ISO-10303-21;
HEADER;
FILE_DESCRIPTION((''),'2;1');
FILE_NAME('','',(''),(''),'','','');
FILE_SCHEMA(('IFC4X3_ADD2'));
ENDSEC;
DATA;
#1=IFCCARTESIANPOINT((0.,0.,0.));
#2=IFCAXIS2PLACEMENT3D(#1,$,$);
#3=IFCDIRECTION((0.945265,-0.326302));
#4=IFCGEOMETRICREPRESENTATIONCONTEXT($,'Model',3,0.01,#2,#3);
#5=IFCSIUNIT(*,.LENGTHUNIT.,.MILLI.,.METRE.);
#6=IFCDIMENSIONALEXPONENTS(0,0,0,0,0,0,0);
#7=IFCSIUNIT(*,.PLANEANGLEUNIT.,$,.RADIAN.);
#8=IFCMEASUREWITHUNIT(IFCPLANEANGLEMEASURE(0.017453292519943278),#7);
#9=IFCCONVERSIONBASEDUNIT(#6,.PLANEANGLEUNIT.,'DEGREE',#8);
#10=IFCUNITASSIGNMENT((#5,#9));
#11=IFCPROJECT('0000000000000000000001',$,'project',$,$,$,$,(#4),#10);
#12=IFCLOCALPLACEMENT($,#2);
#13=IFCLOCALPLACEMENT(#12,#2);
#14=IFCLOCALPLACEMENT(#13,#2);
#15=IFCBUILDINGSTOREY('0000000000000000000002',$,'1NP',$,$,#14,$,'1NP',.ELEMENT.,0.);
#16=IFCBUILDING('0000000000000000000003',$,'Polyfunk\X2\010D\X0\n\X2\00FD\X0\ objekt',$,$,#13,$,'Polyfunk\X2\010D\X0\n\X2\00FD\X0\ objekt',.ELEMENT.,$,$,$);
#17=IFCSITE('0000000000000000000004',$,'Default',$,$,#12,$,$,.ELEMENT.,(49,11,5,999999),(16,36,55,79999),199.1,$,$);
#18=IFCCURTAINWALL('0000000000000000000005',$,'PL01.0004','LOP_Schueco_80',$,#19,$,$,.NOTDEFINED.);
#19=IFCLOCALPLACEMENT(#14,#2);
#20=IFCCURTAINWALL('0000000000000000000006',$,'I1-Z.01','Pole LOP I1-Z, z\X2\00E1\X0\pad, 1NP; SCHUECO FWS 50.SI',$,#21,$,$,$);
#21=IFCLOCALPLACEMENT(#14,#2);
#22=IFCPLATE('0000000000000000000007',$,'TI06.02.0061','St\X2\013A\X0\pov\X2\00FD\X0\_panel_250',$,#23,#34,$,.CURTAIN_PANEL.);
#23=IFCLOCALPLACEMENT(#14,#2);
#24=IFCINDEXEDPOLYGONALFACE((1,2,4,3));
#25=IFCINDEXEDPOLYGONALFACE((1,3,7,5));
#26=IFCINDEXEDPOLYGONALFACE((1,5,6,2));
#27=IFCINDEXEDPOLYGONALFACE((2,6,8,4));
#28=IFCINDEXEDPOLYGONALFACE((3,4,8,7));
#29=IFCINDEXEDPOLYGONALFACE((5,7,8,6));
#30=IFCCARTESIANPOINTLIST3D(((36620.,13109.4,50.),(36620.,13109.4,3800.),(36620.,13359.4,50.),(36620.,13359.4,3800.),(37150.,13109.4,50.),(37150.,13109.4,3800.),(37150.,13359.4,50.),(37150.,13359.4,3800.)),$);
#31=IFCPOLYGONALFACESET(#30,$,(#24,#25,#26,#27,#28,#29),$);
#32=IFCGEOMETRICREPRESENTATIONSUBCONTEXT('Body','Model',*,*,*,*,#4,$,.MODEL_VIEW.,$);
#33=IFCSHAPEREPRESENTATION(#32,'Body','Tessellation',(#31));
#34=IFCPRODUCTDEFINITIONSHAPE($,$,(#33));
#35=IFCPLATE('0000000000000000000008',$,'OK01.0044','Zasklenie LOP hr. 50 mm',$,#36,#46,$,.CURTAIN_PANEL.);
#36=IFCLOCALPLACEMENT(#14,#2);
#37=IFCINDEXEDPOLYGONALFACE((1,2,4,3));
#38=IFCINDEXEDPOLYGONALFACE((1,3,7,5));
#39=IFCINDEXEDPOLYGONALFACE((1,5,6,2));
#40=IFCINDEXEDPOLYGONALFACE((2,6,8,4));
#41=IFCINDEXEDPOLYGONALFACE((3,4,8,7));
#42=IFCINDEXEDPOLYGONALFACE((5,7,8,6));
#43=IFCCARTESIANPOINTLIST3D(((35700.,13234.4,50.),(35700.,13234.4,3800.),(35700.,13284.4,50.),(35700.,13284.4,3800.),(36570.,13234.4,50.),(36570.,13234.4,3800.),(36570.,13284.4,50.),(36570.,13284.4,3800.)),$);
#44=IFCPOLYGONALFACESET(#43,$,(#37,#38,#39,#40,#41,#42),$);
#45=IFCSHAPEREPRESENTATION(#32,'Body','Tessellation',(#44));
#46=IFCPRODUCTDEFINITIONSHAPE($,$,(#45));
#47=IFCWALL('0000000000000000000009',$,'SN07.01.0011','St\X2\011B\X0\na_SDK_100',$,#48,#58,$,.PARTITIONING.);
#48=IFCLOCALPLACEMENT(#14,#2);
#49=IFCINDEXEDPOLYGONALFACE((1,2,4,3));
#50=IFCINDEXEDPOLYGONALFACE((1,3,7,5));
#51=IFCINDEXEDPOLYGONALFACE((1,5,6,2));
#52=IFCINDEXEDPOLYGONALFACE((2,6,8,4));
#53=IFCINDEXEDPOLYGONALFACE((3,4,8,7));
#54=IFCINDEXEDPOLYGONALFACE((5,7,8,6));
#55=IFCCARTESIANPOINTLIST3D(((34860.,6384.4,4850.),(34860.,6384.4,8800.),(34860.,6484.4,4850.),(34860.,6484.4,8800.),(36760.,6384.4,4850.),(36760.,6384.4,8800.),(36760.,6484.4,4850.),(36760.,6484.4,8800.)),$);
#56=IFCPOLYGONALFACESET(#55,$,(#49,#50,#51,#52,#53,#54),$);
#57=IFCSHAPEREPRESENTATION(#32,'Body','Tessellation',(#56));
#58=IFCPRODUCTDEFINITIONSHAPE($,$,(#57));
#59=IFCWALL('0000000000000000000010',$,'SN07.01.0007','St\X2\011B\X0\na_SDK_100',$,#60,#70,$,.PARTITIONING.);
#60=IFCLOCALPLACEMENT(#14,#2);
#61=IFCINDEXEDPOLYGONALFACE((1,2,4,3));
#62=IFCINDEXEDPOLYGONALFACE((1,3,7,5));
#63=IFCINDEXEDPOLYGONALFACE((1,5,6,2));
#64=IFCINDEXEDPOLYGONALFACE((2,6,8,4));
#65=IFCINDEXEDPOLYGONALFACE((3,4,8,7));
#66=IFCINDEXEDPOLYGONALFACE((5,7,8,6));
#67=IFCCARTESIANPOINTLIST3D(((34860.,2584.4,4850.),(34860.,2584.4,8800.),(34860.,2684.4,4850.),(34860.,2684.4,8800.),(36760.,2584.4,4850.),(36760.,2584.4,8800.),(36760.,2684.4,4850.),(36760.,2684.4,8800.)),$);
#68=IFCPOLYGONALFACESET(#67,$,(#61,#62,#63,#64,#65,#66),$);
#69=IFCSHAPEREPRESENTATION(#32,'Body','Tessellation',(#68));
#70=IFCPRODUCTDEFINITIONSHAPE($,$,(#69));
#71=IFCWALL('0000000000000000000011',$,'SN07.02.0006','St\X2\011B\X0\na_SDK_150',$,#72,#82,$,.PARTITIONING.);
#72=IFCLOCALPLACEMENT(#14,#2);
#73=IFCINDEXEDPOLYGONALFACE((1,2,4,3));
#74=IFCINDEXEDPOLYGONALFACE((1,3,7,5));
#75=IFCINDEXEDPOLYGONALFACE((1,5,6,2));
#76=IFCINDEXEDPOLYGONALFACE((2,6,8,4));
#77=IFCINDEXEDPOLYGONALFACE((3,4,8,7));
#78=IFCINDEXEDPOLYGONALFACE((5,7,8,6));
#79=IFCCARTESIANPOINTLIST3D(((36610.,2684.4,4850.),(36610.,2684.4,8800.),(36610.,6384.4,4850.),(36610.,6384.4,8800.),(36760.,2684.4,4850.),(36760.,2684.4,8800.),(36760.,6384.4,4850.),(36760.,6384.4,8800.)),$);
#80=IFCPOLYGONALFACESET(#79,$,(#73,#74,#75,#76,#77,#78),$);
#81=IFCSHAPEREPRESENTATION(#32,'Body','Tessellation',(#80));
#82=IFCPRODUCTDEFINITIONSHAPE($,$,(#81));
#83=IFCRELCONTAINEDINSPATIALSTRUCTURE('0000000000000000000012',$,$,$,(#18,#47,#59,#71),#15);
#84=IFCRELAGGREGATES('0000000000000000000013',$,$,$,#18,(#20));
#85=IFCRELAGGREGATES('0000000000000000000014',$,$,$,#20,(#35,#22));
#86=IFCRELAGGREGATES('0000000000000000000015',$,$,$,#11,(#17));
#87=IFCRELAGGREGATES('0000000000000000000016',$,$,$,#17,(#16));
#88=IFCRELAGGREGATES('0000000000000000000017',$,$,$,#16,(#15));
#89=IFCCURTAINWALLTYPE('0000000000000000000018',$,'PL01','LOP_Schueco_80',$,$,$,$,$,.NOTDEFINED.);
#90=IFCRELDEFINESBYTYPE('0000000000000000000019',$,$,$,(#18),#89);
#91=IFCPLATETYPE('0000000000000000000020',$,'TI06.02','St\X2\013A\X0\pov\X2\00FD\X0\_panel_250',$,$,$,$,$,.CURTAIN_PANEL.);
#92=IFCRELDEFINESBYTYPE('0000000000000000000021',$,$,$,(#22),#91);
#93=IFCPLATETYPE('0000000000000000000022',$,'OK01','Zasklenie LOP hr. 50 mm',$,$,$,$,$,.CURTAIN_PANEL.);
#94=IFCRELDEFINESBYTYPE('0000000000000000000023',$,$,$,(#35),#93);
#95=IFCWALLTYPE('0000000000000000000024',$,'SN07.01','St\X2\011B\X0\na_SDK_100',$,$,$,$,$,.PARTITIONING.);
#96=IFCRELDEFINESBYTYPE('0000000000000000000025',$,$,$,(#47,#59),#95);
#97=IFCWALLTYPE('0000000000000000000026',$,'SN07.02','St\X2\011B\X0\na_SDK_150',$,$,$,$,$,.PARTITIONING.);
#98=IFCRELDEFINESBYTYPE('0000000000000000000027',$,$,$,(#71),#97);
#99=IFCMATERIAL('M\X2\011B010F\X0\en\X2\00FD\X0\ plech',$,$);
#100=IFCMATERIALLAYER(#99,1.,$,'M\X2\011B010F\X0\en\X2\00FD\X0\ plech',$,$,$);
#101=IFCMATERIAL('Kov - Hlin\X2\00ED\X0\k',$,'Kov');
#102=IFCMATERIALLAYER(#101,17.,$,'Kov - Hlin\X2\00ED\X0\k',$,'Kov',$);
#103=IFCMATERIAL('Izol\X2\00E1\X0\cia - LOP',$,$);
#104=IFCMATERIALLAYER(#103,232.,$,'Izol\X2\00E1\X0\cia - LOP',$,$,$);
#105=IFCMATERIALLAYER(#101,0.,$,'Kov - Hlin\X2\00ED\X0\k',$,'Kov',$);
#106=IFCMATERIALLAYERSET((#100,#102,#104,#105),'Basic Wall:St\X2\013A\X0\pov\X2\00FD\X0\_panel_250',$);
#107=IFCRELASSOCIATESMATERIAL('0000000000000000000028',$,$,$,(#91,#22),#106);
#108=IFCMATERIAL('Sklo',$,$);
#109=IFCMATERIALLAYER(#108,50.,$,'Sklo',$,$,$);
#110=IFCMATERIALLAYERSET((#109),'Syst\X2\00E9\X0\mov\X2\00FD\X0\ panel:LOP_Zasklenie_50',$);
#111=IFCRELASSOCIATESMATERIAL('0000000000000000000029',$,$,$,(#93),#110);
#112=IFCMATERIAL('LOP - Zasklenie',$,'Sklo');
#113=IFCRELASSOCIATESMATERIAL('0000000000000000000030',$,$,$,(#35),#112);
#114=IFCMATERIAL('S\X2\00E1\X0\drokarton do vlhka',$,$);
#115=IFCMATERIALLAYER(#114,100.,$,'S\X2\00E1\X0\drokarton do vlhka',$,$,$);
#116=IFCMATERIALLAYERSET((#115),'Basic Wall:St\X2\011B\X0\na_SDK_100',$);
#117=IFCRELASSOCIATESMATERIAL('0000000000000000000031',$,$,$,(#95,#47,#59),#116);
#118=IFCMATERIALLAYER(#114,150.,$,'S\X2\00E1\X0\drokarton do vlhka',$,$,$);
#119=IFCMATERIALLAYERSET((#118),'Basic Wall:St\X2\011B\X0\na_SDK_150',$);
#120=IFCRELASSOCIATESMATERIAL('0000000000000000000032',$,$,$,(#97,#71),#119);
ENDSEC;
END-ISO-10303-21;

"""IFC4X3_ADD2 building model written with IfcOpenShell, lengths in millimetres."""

from ifc_helpers import new_model, entity, si_unit, converted_unit, direction, frame, frame_2d, origin, place, context, subcontext, project, spatial, polyline, rectangle, extrude, clip, bounded_halfspace, source, transform, mapped, material, layer, layer_set, layer_usage, type_object, type_shapes, element, aggregate, save


model = new_model("IFC4X3_ADD2")

# Units and contexts
model_context = context("Model", 3, precision=0.01, world=origin(), true_north=direction((0.945265, -0.326302)))
body_context = subcontext(model_context, "Body", "Model", "MODEL_VIEW")
ifc_project = project(units=[si_unit("LENGTHUNIT", "METRE", prefix="MILLI"), converted_unit("PLANEANGLEUNIT", "DEGREE", entity("IfcPlaneAngleMeasure", 0.017453292519943278), si_unit("PLANEANGLEUNIT", "RADIAN"), dimensions=[0, 0, 0, 0, 0, 0, 0])], contexts=[model_context])

# Site, building, storey
site_placement = place(None, origin())
site = spatial("IfcSite", under=ifc_project, at=site_placement, Name="Default", CompositionType="ELEMENT", RefLatitude=(49, 11, 5, 999999), RefLongitude=(16, 36, 55, 79999), RefElevation=199.1)
building_placement = place(site_placement, origin())
building = spatial("IfcBuilding", under=site, at=building_placement, Name="Polyfunkčný objekt", LongName="Polyfunkčný objekt", CompositionType="ELEMENT")
storey_placement = place(building_placement, origin())
storey = spatial("IfcBuildingStorey", under=building, at=storey_placement, Name="1NP", LongName="1NP", CompositionType="ELEMENT", Elevation=0.0)

# Curtain walls, plates
curtain_wall_type = type_object("IfcCurtainWallType", Name="PL01", Description="LOP_Schueco_80", PredefinedType="NOTDEFINED")
curtain_wall_1_placement = place(storey_placement, origin())
curtain_wall_1 = element("IfcCurtainWall", 1, at=curtain_wall_1_placement, inside=storey, type_object=curtain_wall_type, Name="PL01.0004", Description="LOP_Schueco_80", PredefinedType="NOTDEFINED")
curtain_wall_2 = element("IfcCurtainWall", 2, Name="I1-Z.01", Description="Pole LOP I1-Z, západ, 1NP; SCHUECO FWS 50.SI")
aggregate(curtain_wall_1, [curtain_wall_2])
ifc_material_1 = material(Name="Měďený plech")
ifc_layer_1 = layer(ifc_material_1, 1.0, Name="Měďený plech")
ifc_material_2 = material(Name="Kov - Hliník", Category="Kov")
ifc_layer_2 = layer(ifc_material_2, 17.0, Name="Kov - Hliník", Category="Kov")
ifc_material_3 = material(Name="Izolácia - LOP")
ifc_layer_3 = layer(ifc_material_3, 232.0, Name="Izolácia - LOP")
ifc_layer_4 = layer(ifc_material_2, 0.0, Name="Kov - Hliník", Category="Kov")
ifc_layer_set_1 = layer_set([ifc_layer_1, ifc_layer_2, ifc_layer_3, ifc_layer_4], Name="Basic Wall:Stĺpový_panel_250")
ifc_layer_usage_1 = layer_usage(ifc_layer_set_1, "AXIS2", "NEGATIVE", 125.0)
plate_type_1 = type_object("IfcPlateType", Name="TI06.02", Description="Stĺpový_panel_250", PredefinedType="CURTAIN_PANEL", material=ifc_layer_set_1)
plate_1_placement = place(storey_placement, frame((36620.0, 13234.4, 50.0)))
plate_1 = element("IfcPlate", 3, at=plate_1_placement, type_object=plate_type_1, material=ifc_layer_usage_1, Name="TI06.02.0061", Description="Stĺpový_panel_250", PredefinedType="CURTAIN_PANEL", context=body_context, shape_type="SweptSolid", body=[
    extrude(rectangle(XDim=250.0, YDim=530.0, at=frame_2d((0.0, 0.0), x_axis=(1.0, 0.0))), frame((265.0, 0.0, 0.0), z_axis=(0.0, 0.0, 1.0), x_axis=(0.0, 1.0, 0.0)), (0.0, 0.0, 1.0), 3750.0),
])
ifc_material_4 = material(Name="LOP - Zasklenie", Category="Sklo")
ifc_material_5 = material(Name="Sklo")
ifc_layer_5 = layer(ifc_material_5, 50.0, Name="Sklo")
ifc_layer_set_2 = layer_set([ifc_layer_5], Name="Systémový panel:LOP_Zasklenie_50")
plate_type_2 = type_object("IfcPlateType", Name="OK01", Description="Zasklenie LOP hr. 50 mm", PredefinedType="CURTAIN_PANEL", material=ifc_layer_set_2)
shared_shape_1 = source(origin(), body_context, "Body", "SweptSolid", [
    extrude(rectangle(XDim=3750.0, YDim=870.0, at=frame_2d((-141.7, 0.0), x_axis=(1.0, 0.0))), frame((0.0, 0.0, 2016.7), z_axis=(0.0, 1.0, 0.0), x_axis=(0.0, 0.0, 1.0)), (0.0, 0.0, 1.0), 50.0),
])
type_shapes(plate_type_2, [shared_shape_1])
plate_2_placement = place(curtain_wall_1_placement, frame((36135.0, 13234.4, 50.0)))
plate_2 = element("IfcPlate", 4, at=plate_2_placement, type_object=plate_type_2, material=ifc_material_4, Name="OK01.0044", Description="Zasklenie LOP hr. 50 mm", PredefinedType="CURTAIN_PANEL", context=body_context, shape_type="MappedRepresentation", body=[
    mapped(shared_shape_1, transform((0.0, 0.0, 0.0), scale=1.0)),
])
aggregate(curtain_wall_2, [plate_2, plate_1])

# Walls
ifc_material_6 = material(Name="Sádrokarton do vlhka")
ifc_layer_6 = layer(ifc_material_6, 100.0, Name="Sádrokarton do vlhka")
ifc_layer_set_3 = layer_set([ifc_layer_6], Name="Basic Wall:Stěna_SDK_100")
wall_type_1 = type_object("IfcWallType", Name="SN07.01", Description="Stěna_SDK_100", PredefinedType="PARTITIONING", material=ifc_layer_set_3)
wall_1_placement = place(storey_placement, frame((36760.0, 6434.4, 4850.0), z_axis=(0.0, 0.0, 1.0), x_axis=(-1.0, 0.0, 0.0)))
element("IfcWall", 5, at=wall_1_placement, inside=storey, type_object=wall_type_1, material=ifc_layer_set_3, Name="SN07.01.0011", Description="Stěna_SDK_100", PredefinedType="PARTITIONING", context=body_context, shape_type="Clipping", body=[
    clip(clip(extrude(rectangle(XDim=1900.0, YDim=100.0, at=frame_2d((950.0, 0.0), x_axis=(-1.0, 0.0))), origin(), (0.0, 0.0, 1.0), 3950.0), bounded_halfspace(frame((1900.0, -50.0, 0.0)), True, frame((1900.0, -50.0, 0.0)), polyline([(0.0, 0.0), (0.0, 100.0), (-1750.0, 100.0), (-1900.0, 100.0), (-1900.0, 0.0), (0.0, 0.0)]))), bounded_halfspace(frame((0.0, -50.0, 3950.0), z_axis=(0.0, 0.0, -1.0), x_axis=(-1.0, 0.0, 0.0)), True, frame((0.0, -50.0, 3950.0)), polyline([(0.0, 0.0), (1900.0, 0.0), (1900.0, 100.0), (150.0, 100.0), (0.0, 100.0), (0.0, 0.0)]))),
])
wall_2_placement = place(storey_placement, frame((34860.0, 2634.4, 4850.0)))
element("IfcWall", 6, at=wall_2_placement, inside=storey, type_object=wall_type_1, material=ifc_layer_set_3, Name="SN07.01.0007", Description="Stěna_SDK_100", PredefinedType="PARTITIONING", context=body_context, shape_type="Clipping", body=[
    clip(clip(extrude(rectangle(XDim=1900.0, YDim=100.0, at=frame_2d((950.0, 0.0), x_axis=(-1.0, 0.0))), origin(), (0.0, 0.0, 1.0), 3950.0), bounded_halfspace(frame((1900.0, -50.0, 0.0), z_axis=(0.0, 0.0, 1.0), x_axis=(-1.0, 0.0, 0.0)), True, frame((1900.0, -50.0, 0.0)), polyline([(0.0, 0.0), (0.0, 100.0), (-150.0, 100.0), (-1900.0, 100.0), (-1900.0, 0.0), (-1800.0, 0.0), (0.0, 0.0)]))), bounded_halfspace(frame((0.0, -50.0, 3950.0), z_axis=(0.0, 0.0, -1.0), x_axis=(1.0, 0.0, 0.0)), True, frame((0.0, -50.0, 3950.0)), polyline([(0.0, 0.0), (100.0, 0.0), (1900.0, 0.0), (1900.0, 100.0), (1750.0, 100.0), (0.0, 100.0), (0.0, 0.0)]))),
])
ifc_layer_7 = layer(ifc_material_6, 150.0, Name="Sádrokarton do vlhka")
ifc_layer_set_4 = layer_set([ifc_layer_7], Name="Basic Wall:Stěna_SDK_150")
wall_type_2 = type_object("IfcWallType", Name="SN07.02", Description="Stěna_SDK_150", PredefinedType="PARTITIONING", material=ifc_layer_set_4)
wall_3_placement = place(storey_placement, frame((36685.0, 6384.4, 4850.0), z_axis=(0.0, 0.0, 1.0), x_axis=(0.0, -1.0, 0.0)))
element("IfcWall", 7, at=wall_3_placement, inside=storey, type_object=wall_type_2, material=ifc_layer_set_4, Name="SN07.02.0006", Description="Stěna_SDK_150", PredefinedType="PARTITIONING", context=body_context, shape_type="SweptSolid", body=[
    extrude(rectangle(XDim=3700.0, YDim=150.0, at=frame_2d((1850.0, 0.0), x_axis=(-1.0, 0.0))), origin(), (0.0, 0.0, 1.0), 3950.0),
])

save(model, "model.ifc")
